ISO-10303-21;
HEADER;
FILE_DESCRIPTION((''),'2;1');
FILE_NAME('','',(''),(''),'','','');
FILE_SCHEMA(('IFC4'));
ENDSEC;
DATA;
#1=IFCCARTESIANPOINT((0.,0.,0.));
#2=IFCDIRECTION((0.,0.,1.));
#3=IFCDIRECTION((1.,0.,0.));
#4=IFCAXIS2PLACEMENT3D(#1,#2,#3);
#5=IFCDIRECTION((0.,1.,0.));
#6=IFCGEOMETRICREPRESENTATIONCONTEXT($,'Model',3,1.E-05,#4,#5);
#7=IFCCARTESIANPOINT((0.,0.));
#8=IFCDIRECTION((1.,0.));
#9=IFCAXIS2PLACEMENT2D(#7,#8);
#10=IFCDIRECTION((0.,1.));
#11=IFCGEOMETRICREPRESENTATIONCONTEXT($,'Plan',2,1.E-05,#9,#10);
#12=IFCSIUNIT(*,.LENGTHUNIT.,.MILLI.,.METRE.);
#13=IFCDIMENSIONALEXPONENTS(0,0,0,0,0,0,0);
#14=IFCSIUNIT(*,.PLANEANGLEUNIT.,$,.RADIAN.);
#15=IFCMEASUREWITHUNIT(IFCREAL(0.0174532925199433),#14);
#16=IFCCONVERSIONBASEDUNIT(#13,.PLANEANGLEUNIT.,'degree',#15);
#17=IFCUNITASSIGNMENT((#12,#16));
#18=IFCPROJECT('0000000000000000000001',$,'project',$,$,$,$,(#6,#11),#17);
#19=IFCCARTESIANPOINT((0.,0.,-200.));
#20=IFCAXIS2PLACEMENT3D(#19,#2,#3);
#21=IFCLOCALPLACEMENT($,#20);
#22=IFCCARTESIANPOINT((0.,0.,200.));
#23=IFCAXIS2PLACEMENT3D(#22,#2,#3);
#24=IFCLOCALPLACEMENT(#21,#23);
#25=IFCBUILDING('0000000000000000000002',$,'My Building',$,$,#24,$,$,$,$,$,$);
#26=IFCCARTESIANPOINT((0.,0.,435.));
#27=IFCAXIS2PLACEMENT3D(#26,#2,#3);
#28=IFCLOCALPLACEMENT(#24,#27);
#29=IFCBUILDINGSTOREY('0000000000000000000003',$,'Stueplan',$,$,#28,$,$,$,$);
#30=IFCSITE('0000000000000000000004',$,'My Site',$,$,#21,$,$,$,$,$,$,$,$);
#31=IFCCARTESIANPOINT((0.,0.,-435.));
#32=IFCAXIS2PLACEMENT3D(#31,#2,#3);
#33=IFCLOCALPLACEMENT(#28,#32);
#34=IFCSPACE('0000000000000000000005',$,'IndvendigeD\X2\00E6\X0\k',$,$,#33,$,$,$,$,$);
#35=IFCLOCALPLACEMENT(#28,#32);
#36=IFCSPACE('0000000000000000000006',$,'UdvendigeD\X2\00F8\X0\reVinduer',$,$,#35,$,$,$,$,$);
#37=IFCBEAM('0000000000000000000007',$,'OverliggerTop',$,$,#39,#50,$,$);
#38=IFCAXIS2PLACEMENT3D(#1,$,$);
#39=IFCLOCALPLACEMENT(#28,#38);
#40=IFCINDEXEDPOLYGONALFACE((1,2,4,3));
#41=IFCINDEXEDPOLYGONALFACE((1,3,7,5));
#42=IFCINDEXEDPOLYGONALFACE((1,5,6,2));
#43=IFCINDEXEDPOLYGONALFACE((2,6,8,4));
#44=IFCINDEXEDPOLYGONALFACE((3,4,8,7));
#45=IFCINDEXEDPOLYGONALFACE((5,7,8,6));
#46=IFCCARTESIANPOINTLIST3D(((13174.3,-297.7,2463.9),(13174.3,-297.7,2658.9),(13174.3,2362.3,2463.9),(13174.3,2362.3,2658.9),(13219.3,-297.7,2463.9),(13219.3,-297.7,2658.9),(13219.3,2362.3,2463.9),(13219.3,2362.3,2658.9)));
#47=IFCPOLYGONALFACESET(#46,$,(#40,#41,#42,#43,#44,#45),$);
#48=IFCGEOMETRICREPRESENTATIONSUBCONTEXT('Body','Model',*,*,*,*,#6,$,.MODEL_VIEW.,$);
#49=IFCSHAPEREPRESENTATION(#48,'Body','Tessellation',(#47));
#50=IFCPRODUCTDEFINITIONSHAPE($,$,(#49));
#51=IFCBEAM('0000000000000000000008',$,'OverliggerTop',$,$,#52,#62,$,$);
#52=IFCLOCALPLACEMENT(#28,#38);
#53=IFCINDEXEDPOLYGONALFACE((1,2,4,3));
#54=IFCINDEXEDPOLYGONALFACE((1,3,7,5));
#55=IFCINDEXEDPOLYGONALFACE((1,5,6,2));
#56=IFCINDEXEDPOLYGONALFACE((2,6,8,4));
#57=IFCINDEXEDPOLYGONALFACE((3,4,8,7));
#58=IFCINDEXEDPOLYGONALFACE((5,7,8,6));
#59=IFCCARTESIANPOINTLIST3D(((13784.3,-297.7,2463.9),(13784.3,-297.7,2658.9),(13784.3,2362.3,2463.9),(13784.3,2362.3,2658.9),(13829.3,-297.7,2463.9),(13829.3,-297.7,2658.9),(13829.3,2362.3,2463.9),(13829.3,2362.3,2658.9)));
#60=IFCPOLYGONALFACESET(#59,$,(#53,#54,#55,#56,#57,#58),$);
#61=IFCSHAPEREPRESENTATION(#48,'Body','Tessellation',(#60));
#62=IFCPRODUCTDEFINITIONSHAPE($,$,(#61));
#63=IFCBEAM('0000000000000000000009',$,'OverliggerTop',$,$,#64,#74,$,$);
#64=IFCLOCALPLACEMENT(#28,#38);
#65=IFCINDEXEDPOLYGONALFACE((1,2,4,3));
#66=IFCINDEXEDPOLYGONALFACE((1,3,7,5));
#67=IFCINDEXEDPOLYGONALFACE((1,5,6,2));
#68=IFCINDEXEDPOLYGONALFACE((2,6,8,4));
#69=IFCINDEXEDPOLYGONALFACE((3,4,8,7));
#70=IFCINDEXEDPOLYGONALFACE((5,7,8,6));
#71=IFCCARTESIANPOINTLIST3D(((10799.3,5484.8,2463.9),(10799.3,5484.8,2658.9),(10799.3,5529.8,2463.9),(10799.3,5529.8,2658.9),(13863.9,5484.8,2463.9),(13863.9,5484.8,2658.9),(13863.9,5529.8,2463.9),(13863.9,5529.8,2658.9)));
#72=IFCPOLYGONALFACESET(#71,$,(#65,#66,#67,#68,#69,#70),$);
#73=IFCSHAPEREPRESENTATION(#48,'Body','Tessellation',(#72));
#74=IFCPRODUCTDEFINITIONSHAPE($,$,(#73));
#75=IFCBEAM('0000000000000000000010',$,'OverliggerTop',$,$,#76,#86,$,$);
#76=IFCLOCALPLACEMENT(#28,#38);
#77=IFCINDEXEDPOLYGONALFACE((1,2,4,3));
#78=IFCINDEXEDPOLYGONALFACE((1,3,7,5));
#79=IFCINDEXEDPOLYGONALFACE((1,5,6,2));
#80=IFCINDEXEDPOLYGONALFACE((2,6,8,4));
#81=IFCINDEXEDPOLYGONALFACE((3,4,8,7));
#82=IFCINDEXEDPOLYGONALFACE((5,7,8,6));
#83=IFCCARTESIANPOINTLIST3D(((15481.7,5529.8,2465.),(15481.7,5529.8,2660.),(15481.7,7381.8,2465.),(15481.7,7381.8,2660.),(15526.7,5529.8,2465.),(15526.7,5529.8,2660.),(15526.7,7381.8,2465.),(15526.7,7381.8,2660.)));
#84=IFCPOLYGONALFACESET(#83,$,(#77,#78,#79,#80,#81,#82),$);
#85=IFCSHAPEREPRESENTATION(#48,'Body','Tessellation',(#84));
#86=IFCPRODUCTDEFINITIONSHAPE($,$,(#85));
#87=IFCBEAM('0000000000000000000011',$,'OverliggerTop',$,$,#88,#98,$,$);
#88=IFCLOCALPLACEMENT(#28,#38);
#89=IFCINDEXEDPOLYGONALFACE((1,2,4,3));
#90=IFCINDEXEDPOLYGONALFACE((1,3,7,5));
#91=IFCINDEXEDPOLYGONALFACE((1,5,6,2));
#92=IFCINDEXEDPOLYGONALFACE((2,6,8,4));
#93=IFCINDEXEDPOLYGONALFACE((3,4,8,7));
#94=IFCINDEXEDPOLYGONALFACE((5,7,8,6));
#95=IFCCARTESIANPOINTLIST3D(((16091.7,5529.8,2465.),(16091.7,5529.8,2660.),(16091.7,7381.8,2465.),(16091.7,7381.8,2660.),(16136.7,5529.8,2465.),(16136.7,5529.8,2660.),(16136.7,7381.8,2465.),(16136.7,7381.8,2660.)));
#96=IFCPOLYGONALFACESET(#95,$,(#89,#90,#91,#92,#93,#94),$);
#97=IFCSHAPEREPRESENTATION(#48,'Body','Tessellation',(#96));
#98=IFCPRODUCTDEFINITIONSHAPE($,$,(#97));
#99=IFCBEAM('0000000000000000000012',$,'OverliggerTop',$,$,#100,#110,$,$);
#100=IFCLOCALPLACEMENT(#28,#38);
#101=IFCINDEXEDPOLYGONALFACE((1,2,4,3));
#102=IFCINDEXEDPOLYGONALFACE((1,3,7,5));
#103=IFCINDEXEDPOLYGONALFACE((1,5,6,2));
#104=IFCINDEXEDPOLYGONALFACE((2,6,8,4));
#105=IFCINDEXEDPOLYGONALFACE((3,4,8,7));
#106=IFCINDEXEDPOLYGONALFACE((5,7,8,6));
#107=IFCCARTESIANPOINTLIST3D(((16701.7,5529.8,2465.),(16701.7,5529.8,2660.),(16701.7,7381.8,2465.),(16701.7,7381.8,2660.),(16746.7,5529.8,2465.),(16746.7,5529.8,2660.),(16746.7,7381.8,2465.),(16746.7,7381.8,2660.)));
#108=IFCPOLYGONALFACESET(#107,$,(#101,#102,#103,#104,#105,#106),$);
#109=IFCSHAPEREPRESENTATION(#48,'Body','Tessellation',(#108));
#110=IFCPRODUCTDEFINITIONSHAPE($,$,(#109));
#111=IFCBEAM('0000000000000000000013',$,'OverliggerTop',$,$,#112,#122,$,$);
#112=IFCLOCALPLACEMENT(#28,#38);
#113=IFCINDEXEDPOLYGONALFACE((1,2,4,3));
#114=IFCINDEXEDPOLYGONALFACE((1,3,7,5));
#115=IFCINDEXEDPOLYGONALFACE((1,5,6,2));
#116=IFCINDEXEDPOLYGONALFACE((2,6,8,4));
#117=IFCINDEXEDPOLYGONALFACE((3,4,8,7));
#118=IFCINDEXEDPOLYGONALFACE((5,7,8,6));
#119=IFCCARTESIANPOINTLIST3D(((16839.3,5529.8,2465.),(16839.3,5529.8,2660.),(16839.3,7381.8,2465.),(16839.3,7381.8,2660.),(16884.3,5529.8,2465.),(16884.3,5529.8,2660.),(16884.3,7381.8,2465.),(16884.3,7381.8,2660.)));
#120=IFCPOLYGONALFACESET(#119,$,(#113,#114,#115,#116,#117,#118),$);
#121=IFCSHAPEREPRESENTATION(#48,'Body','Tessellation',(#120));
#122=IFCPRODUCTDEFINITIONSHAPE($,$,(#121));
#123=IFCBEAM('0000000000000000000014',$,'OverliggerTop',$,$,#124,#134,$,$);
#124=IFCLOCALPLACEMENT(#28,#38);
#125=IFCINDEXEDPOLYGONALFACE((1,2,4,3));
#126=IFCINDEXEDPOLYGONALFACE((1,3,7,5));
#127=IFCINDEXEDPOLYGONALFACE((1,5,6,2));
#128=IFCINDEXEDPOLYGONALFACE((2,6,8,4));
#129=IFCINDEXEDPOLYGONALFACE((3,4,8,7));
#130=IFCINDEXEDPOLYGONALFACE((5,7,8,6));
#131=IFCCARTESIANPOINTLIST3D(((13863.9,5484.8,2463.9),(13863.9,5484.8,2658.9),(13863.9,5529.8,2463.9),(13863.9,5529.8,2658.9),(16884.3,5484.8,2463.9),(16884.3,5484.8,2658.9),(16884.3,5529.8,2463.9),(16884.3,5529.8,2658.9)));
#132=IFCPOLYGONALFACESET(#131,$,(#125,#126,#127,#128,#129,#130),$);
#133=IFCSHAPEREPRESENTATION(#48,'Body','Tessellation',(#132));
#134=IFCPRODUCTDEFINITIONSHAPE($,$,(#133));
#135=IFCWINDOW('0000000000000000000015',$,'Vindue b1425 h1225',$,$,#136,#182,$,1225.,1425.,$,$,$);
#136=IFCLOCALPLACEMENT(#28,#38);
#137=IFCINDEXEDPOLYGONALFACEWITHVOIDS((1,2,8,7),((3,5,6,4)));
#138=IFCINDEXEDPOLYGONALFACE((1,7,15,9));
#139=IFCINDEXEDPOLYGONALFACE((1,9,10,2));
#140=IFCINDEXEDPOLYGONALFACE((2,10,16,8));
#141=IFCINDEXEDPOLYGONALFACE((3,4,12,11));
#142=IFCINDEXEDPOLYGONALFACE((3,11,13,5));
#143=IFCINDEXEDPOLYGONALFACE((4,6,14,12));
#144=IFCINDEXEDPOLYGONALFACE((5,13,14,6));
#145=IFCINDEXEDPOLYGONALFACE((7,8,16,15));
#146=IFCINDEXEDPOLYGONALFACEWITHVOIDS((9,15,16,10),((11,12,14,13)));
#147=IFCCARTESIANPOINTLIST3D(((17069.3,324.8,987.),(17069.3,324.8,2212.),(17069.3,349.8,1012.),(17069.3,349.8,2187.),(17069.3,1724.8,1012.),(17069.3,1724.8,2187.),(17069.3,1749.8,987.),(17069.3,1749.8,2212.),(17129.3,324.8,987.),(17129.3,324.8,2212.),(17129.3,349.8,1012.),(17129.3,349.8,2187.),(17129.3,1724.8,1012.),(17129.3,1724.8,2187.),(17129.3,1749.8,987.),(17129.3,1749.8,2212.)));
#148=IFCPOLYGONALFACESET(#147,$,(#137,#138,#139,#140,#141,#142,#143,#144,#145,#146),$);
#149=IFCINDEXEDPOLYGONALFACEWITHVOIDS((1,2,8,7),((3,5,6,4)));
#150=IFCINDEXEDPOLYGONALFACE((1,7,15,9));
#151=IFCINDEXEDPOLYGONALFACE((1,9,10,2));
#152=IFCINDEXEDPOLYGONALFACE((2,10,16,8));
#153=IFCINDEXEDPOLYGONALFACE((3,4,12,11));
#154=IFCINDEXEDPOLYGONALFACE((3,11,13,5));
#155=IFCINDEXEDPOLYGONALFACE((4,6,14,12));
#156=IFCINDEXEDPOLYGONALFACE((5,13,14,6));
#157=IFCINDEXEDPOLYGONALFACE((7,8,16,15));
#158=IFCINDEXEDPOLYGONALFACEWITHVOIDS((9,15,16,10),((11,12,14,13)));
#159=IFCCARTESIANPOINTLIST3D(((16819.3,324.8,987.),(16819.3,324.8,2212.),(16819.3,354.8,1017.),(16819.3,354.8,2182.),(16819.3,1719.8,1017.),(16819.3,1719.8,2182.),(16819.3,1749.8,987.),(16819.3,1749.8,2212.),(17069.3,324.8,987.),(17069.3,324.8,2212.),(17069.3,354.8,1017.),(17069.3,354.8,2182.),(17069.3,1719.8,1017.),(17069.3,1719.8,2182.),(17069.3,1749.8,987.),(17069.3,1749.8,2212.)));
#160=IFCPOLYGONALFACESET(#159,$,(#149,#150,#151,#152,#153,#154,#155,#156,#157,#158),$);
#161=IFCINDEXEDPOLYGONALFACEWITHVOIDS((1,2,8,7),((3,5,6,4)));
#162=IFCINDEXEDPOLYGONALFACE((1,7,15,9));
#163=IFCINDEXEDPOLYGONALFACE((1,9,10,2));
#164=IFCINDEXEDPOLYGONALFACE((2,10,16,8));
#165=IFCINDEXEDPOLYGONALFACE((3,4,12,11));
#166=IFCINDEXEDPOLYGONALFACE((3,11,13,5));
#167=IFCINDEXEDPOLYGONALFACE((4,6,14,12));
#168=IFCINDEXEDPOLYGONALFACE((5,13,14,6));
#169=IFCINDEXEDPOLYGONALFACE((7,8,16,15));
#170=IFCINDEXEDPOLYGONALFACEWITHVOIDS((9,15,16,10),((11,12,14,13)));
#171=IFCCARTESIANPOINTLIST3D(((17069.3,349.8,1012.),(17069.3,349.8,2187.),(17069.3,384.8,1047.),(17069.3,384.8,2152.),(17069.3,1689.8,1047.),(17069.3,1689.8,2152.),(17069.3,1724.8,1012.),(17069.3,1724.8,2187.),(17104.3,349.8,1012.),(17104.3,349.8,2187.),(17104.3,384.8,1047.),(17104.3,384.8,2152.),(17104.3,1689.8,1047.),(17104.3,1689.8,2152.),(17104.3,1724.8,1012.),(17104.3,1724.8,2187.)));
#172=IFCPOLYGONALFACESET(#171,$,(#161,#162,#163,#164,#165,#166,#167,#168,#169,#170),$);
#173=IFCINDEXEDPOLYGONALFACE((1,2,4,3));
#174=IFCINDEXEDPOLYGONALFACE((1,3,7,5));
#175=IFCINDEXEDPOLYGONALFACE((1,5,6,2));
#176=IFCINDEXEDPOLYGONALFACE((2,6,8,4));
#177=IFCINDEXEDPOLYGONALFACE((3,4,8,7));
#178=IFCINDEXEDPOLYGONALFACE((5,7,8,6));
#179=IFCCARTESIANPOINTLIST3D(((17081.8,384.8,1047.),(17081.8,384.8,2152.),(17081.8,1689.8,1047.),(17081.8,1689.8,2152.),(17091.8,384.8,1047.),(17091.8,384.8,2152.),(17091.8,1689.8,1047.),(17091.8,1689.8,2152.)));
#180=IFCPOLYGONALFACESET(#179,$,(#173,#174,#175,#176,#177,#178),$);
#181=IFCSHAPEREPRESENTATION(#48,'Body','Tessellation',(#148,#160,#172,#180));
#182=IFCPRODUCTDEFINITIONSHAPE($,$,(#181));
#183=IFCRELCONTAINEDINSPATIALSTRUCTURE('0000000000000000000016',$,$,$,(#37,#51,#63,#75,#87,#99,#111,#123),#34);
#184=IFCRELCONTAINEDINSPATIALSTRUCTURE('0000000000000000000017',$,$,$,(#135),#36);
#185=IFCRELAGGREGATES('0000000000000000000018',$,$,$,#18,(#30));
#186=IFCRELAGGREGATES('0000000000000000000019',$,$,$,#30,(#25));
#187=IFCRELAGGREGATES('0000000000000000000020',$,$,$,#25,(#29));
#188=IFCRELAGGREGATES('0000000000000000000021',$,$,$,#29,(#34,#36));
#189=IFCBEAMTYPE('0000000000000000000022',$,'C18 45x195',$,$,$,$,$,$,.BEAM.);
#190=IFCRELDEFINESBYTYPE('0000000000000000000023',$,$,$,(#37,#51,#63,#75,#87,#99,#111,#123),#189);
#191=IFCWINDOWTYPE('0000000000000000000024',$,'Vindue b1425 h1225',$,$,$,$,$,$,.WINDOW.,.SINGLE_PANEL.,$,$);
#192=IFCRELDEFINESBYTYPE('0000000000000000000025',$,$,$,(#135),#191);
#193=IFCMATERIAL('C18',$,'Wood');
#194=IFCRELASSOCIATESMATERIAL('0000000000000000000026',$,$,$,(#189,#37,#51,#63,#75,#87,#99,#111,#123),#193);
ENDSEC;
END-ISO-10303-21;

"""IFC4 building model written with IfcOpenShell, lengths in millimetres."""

from ifc_helpers import new_model, entity, si_unit, converted_unit, direction, frame, origin_with_axes, origin_2d_with_axis, place, context, subcontext, project, spatial, line, indexed_curve, rectangle, outline, extrude, shape, source, transform, mapped, material, material_profile, profile_set, profile_usage, type_object, type_shapes, element, save


model = new_model("IFC4")

# Units and contexts
model_context = context("Model", 3, precision=1e-05, world=origin_with_axes(), true_north=direction((0.0, 1.0, 0.0)))
plan_context = context("Plan", 2, precision=1e-05, world=origin_2d_with_axis(), true_north=direction((0.0, 1.0)))
body_context_1 = subcontext(model_context, "Body", "Model", "MODEL_VIEW")
body_context_2 = subcontext(plan_context, "Body", "Plan", "PLAN_VIEW")
ifc_project = project(units=[si_unit("LENGTHUNIT", "METRE", prefix="MILLI"), converted_unit("PLANEANGLEUNIT", "degree", entity("IfcReal", 0.0174532925199433), si_unit("PLANEANGLEUNIT", "RADIAN"), dimensions=[0, 0, 0, 0, 0, 0, 0])], contexts=[model_context, plan_context])

# Site, building, storey
site_placement = place(None, frame((0.0, 0.0, -200.0), z_axis=(0.0, 0.0, 1.0), x_axis=(1.0, 0.0, 0.0)))
site = spatial("IfcSite", under=ifc_project, at=site_placement, Name="My Site")
building_placement = place(site_placement, frame((0.0, 0.0, 200.0), z_axis=(0.0, 0.0, 1.0), x_axis=(1.0, 0.0, 0.0)))
building = spatial("IfcBuilding", under=site, at=building_placement, Name="My Building")
storey_placement = place(building_placement, frame((0.0, 0.0, 435.0), z_axis=(0.0, 0.0, 1.0), x_axis=(1.0, 0.0, 0.0)))
storey = spatial("IfcBuildingStorey", under=building, at=storey_placement, Name="Stueplan")

# Shared definitions
ifc_material = material(Name="C18", Category="Wood")

# Shared definitions
space_1_placement = place(storey_placement, frame((0.0, 0.0, -435.0), z_axis=(0.0, 0.0, 1.0), x_axis=(1.0, 0.0, 0.0)))
space_1 = spatial("IfcSpace", under=storey, at=space_1_placement, Name="IndvendigeDæk")

# Beams
ifc_material_profile_1 = material_profile(ifc_material, rectangle(XDim=45.0, YDim=195.0))
ifc_profile_set_1 = profile_set([ifc_material_profile_1], Name="woodStructural")
beam_type_1 = type_object("IfcBeamType", Name="C18 45x195", PredefinedType="BEAM", material=ifc_profile_set_1)
ifc_profile_usage_1 = profile_usage(ifc_profile_set_1)
beam_1_placement = place(space_1_placement, frame((13196.8, 2362.3, 2996.4), z_axis=(0.000001, -1.0, 0.0), x_axis=(-1.0, -0.000001, 0.0)))
element("IfcBeam", 1, at=beam_1_placement, inside=space_1, type_object=beam_type_1, material=ifc_profile_usage_1, Name="OverliggerTop", context=body_context_1, shape_type="SweptSolid", body=[
    extrude(rectangle(XDim=45.0, YDim=195.0), origin_with_axes(), (0.0, 0.0, 1.0), 2660.0),
])
ifc_profile_usage_2 = profile_usage(ifc_profile_set_1)
beam_2_placement = place(space_1_placement, frame((13806.8, 2362.3, 2996.4), z_axis=(0.000001, -1.0, 0.0), x_axis=(-1.0, -0.000001, 0.0)))
element("IfcBeam", 2, at=beam_2_placement, inside=space_1, type_object=beam_type_1, material=ifc_profile_usage_2, Name="OverliggerTop", context=body_context_1, shape_type="SweptSolid", body=[
    extrude(rectangle(XDim=45.0, YDim=195.0), origin_with_axes(), (0.0, 0.0, 1.0), 2660.0),
])
ifc_profile_usage_3 = profile_usage(ifc_profile_set_1)
beam_3_placement = place(space_1_placement, frame((13863.9, 5507.3, 2996.4), z_axis=(-1.0, 0.0, 0.0), x_axis=(0.0, 1.0, 0.0)))
element("IfcBeam", 3, at=beam_3_placement, inside=space_1, type_object=beam_type_1, material=ifc_profile_usage_3, Name="OverliggerTop", context=body_context_1, shape_type="SweptSolid", body=[
    extrude(rectangle(XDim=45.0, YDim=195.0), origin_with_axes(), (0.0, 0.0, 1.0), 3064.7),
])
ifc_profile_usage_4 = profile_usage(ifc_profile_set_1)
beam_4_placement = place(space_1_placement, frame((15504.2, 5529.8, 2997.5), z_axis=(-0.000001, 1.0, 0.0), x_axis=(1.0, 0.000001, 0.0)))
element("IfcBeam", 4, at=beam_4_placement, inside=space_1, type_object=beam_type_1, material=ifc_profile_usage_4, Name="OverliggerTop", context=body_context_1, shape_type="SweptSolid", body=[
    extrude(rectangle(XDim=45.0, YDim=195.0), origin_with_axes(), (0.0, 0.0, 1.0), 1852.0),
])
ifc_profile_usage_5 = profile_usage(ifc_profile_set_1)
beam_5_placement = place(space_1_placement, frame((16114.2, 5529.8, 2997.5), z_axis=(-0.000001, 1.0, 0.0), x_axis=(1.0, 0.000001, 0.0)))
element("IfcBeam", 5, at=beam_5_placement, inside=space_1, type_object=beam_type_1, material=ifc_profile_usage_5, Name="OverliggerTop", context=body_context_1, shape_type="SweptSolid", body=[
    extrude(rectangle(XDim=45.0, YDim=195.0), origin_with_axes(), (0.0, 0.0, 1.0), 1852.0),
])
ifc_profile_usage_6 = profile_usage(ifc_profile_set_1)
beam_6_placement = place(space_1_placement, frame((16724.2, 5529.8, 2997.5), z_axis=(-0.000001, 1.0, 0.0), x_axis=(1.0, 0.000001, 0.0)))
element("IfcBeam", 6, at=beam_6_placement, inside=space_1, type_object=beam_type_1, material=ifc_profile_usage_6, Name="OverliggerTop", context=body_context_1, shape_type="SweptSolid", body=[
    extrude(rectangle(XDim=45.0, YDim=195.0), origin_with_axes(), (0.0, 0.0, 1.0), 1852.0),
])
ifc_profile_usage_7 = profile_usage(ifc_profile_set_1)
beam_7_placement = place(space_1_placement, frame((16861.8, 5529.8, 2997.5), z_axis=(-0.000001, 1.0, 0.0), x_axis=(1.0, 0.000001, 0.0)))
element("IfcBeam", 7, at=beam_7_placement, inside=space_1, type_object=beam_type_1, material=ifc_profile_usage_7, Name="OverliggerTop", context=body_context_1, shape_type="SweptSolid", body=[
    extrude(rectangle(XDim=45.0, YDim=195.0), origin_with_axes(), (0.0, 0.0, 1.0), 1852.0),
])
ifc_profile_usage_8 = profile_usage(ifc_profile_set_1)
beam_8_placement = place(space_1_placement, frame((16884.3, 5507.3, 2996.4), z_axis=(-1.0, 0.0, 0.0), x_axis=(0.0, 1.0, 0.0)))
element("IfcBeam", 8, at=beam_8_placement, inside=space_1, type_object=beam_type_1, material=ifc_profile_usage_8, Name="OverliggerTop", context=body_context_1, shape_type="SweptSolid", body=[
    extrude(rectangle(XDim=45.0, YDim=195.0), origin_with_axes(), (0.0, 0.0, 1.0), 3020.3),
])

# Shared definitions
space_2_placement = place(storey_placement, frame((0.0, 0.0, -435.0), z_axis=(0.0, 0.0, 1.0), x_axis=(1.0, 0.0, 0.0)))
space_2 = spatial("IfcSpace", under=storey, at=space_2_placement, Name="UdvendigeDøreVinduer")

# Window
window_type = type_object("IfcWindowType", Name="Vindue b1425 h1225", PartitioningType="SINGLE_PANEL", PredefinedType="WINDOW")
shared_shape_1 = source(origin_with_axes(), body_context_1, "Body", "SweptSolid", [
    extrude(outline(indexed_curve([(0.0, 0.0), (1425.0, 0.0), (1425.0, 1225.0), (0.0, 1225.0)], segments=[line(1, 2, 3, 4, 1)]), holes=[indexed_curve([(25.0, 25.0), (1400.0, 25.0), (1400.0, 1200.0), (25.0, 1200.0)], segments=[line(1, 2, 3, 4, 1)])]), frame((0.0, 250.0, 0.0), z_axis=(0.0, -1.0, 0.0), x_axis=(1.0, 0.0, 0.0)), (0.0, 0.0, -1.0), 60.0),
    extrude(outline(indexed_curve([(0.0, 0.0), (1425.0, 0.0), (1425.0, 1225.0), (0.0, 1225.0)], segments=[line(1, 2, 3, 4, 1)]), holes=[indexed_curve([(30.0, 30.0), (1395.0, 30.0), (1395.0, 1195.0), (30.0, 1195.0)], segments=[line(1, 2, 3, 4, 1)])]), frame((0.0, 0.0, 0.0), z_axis=(0.0, -1.0, 0.0), x_axis=(1.0, 0.0, 0.0)), (0.0, 0.0, -1.0), 250.0),
    extrude(outline(indexed_curve([(0.0, 0.0), (1375.0, 0.0), (1375.0, 1175.0), (0.0, 1175.0)], segments=[line(1, 2, 3, 4, 1)]), holes=[indexed_curve([(35.0, 35.0), (1340.0, 35.0), (1340.0, 1140.0), (35.0, 1140.0)], segments=[line(1, 2, 3, 4, 1)])]), frame((25.0, 250.0, 25.0), z_axis=(0.0, -1.0, 0.0), x_axis=(1.0, 0.0, 0.0)), (0.0, 0.0, -1.0), 35.0),
    extrude(outline(indexed_curve([(35.0, 35.0), (1340.0, 35.0), (1340.0, 1140.0), (35.0, 1140.0)], segments=[line(1, 2, 3, 4, 1)])), frame((25.0, 262.5, 25.0), z_axis=(0.0, -1.0, 0.0), x_axis=(1.0, 0.0, 0.0)), (0.0, 0.0, -1.0), 10.0),
])
shared_shape_2 = source(origin_with_axes(), body_context_2, "Body", "Curve2D", [
    entity("IfcIndexedPolyCurve", entity("IfcCartesianPointList2D", [[30.0, 0.0], [1395.0, 0.0]])),
    entity("IfcIndexedPolyCurve", entity("IfcCartesianPointList2D", [[0.0, 310.0], [25.0, 310.0], [25.0, 250.0], [30.0, 250.0], [30.0, 0.0], [0.0, 0.0]]), [entity("IfcLineIndex", [1, 2, 3, 4, 5, 6, 1])]),
    entity("IfcIndexedPolyCurve", entity("IfcCartesianPointList2D", [[1425.0, 310.0], [1400.0, 310.0], [1400.0, 250.0], [1395.0, 250.0], [1395.0, 0.0], [1425.0, 0.0]]), [entity("IfcLineIndex", [1, 2, 3, 4, 5, 6, 1])]),
    entity("IfcIndexedPolyCurve", entity("IfcCartesianPointList2D", [[25.0, 250.0], [60.0, 250.0], [60.0, 285.0], [25.0, 285.0]]), [entity("IfcLineIndex", [1, 2, 3, 4, 1])]),
    entity("IfcIndexedPolyCurve", entity("IfcCartesianPointList2D", [[1400.0, 250.0], [1365.0, 250.0], [1365.0, 285.0], [1400.0, 285.0]]), [entity("IfcLineIndex", [1, 2, 3, 4, 1])]),
    entity("IfcIndexedPolyCurve", entity("IfcCartesianPointList2D", [[60.0, 250.0], [1365.0, 250.0]])),
    entity("IfcIndexedPolyCurve", entity("IfcCartesianPointList2D", [[60.0, 285.0], [1365.0, 285.0]])),
    entity("IfcIndexedPolyCurve", entity("IfcCartesianPointList2D", [[60.0, 267.5], [1365.0, 267.5]])),
])
type_shapes(window_type, [shared_shape_1, shared_shape_2])
for number, where, z_axis, x_axis, name in (
    (9, (16819.3, 1749.8, 1422.0), (0.0, 0.0, 1.0), (0.0, -1.0, 0.0), "Vindue b1425 h1225"),
):
    element("IfcWindow", number, at=place(space_2_placement, frame(where, z_axis=z_axis, x_axis=x_axis)), inside=space_2, type_object=window_type, Name=name, OverallHeight=1225.0, OverallWidth=1425.0, shapes=[
        shape(body_context_1, "Body", "MappedRepresentation", [mapped(shared_shape_1, transform((0.0, 0.0, 0.0), x_axis=(1.0, 0.0, 0.0), y_axis=(0.0, 1.0, 0.0), z_axis=(0.0, 0.0, 1.0), scale=1.0))]),
        shape(body_context_2, "Body", "MappedRepresentation", [mapped(shared_shape_2, transform((0.0, 0.0, 0.0), x_axis=(1.0, 0.0, 0.0), y_axis=(0.0, 1.0, 0.0), z_axis=(0.0, 0.0, 1.0), scale=1.0))]),
    ])

save(model, "model.ifc")
